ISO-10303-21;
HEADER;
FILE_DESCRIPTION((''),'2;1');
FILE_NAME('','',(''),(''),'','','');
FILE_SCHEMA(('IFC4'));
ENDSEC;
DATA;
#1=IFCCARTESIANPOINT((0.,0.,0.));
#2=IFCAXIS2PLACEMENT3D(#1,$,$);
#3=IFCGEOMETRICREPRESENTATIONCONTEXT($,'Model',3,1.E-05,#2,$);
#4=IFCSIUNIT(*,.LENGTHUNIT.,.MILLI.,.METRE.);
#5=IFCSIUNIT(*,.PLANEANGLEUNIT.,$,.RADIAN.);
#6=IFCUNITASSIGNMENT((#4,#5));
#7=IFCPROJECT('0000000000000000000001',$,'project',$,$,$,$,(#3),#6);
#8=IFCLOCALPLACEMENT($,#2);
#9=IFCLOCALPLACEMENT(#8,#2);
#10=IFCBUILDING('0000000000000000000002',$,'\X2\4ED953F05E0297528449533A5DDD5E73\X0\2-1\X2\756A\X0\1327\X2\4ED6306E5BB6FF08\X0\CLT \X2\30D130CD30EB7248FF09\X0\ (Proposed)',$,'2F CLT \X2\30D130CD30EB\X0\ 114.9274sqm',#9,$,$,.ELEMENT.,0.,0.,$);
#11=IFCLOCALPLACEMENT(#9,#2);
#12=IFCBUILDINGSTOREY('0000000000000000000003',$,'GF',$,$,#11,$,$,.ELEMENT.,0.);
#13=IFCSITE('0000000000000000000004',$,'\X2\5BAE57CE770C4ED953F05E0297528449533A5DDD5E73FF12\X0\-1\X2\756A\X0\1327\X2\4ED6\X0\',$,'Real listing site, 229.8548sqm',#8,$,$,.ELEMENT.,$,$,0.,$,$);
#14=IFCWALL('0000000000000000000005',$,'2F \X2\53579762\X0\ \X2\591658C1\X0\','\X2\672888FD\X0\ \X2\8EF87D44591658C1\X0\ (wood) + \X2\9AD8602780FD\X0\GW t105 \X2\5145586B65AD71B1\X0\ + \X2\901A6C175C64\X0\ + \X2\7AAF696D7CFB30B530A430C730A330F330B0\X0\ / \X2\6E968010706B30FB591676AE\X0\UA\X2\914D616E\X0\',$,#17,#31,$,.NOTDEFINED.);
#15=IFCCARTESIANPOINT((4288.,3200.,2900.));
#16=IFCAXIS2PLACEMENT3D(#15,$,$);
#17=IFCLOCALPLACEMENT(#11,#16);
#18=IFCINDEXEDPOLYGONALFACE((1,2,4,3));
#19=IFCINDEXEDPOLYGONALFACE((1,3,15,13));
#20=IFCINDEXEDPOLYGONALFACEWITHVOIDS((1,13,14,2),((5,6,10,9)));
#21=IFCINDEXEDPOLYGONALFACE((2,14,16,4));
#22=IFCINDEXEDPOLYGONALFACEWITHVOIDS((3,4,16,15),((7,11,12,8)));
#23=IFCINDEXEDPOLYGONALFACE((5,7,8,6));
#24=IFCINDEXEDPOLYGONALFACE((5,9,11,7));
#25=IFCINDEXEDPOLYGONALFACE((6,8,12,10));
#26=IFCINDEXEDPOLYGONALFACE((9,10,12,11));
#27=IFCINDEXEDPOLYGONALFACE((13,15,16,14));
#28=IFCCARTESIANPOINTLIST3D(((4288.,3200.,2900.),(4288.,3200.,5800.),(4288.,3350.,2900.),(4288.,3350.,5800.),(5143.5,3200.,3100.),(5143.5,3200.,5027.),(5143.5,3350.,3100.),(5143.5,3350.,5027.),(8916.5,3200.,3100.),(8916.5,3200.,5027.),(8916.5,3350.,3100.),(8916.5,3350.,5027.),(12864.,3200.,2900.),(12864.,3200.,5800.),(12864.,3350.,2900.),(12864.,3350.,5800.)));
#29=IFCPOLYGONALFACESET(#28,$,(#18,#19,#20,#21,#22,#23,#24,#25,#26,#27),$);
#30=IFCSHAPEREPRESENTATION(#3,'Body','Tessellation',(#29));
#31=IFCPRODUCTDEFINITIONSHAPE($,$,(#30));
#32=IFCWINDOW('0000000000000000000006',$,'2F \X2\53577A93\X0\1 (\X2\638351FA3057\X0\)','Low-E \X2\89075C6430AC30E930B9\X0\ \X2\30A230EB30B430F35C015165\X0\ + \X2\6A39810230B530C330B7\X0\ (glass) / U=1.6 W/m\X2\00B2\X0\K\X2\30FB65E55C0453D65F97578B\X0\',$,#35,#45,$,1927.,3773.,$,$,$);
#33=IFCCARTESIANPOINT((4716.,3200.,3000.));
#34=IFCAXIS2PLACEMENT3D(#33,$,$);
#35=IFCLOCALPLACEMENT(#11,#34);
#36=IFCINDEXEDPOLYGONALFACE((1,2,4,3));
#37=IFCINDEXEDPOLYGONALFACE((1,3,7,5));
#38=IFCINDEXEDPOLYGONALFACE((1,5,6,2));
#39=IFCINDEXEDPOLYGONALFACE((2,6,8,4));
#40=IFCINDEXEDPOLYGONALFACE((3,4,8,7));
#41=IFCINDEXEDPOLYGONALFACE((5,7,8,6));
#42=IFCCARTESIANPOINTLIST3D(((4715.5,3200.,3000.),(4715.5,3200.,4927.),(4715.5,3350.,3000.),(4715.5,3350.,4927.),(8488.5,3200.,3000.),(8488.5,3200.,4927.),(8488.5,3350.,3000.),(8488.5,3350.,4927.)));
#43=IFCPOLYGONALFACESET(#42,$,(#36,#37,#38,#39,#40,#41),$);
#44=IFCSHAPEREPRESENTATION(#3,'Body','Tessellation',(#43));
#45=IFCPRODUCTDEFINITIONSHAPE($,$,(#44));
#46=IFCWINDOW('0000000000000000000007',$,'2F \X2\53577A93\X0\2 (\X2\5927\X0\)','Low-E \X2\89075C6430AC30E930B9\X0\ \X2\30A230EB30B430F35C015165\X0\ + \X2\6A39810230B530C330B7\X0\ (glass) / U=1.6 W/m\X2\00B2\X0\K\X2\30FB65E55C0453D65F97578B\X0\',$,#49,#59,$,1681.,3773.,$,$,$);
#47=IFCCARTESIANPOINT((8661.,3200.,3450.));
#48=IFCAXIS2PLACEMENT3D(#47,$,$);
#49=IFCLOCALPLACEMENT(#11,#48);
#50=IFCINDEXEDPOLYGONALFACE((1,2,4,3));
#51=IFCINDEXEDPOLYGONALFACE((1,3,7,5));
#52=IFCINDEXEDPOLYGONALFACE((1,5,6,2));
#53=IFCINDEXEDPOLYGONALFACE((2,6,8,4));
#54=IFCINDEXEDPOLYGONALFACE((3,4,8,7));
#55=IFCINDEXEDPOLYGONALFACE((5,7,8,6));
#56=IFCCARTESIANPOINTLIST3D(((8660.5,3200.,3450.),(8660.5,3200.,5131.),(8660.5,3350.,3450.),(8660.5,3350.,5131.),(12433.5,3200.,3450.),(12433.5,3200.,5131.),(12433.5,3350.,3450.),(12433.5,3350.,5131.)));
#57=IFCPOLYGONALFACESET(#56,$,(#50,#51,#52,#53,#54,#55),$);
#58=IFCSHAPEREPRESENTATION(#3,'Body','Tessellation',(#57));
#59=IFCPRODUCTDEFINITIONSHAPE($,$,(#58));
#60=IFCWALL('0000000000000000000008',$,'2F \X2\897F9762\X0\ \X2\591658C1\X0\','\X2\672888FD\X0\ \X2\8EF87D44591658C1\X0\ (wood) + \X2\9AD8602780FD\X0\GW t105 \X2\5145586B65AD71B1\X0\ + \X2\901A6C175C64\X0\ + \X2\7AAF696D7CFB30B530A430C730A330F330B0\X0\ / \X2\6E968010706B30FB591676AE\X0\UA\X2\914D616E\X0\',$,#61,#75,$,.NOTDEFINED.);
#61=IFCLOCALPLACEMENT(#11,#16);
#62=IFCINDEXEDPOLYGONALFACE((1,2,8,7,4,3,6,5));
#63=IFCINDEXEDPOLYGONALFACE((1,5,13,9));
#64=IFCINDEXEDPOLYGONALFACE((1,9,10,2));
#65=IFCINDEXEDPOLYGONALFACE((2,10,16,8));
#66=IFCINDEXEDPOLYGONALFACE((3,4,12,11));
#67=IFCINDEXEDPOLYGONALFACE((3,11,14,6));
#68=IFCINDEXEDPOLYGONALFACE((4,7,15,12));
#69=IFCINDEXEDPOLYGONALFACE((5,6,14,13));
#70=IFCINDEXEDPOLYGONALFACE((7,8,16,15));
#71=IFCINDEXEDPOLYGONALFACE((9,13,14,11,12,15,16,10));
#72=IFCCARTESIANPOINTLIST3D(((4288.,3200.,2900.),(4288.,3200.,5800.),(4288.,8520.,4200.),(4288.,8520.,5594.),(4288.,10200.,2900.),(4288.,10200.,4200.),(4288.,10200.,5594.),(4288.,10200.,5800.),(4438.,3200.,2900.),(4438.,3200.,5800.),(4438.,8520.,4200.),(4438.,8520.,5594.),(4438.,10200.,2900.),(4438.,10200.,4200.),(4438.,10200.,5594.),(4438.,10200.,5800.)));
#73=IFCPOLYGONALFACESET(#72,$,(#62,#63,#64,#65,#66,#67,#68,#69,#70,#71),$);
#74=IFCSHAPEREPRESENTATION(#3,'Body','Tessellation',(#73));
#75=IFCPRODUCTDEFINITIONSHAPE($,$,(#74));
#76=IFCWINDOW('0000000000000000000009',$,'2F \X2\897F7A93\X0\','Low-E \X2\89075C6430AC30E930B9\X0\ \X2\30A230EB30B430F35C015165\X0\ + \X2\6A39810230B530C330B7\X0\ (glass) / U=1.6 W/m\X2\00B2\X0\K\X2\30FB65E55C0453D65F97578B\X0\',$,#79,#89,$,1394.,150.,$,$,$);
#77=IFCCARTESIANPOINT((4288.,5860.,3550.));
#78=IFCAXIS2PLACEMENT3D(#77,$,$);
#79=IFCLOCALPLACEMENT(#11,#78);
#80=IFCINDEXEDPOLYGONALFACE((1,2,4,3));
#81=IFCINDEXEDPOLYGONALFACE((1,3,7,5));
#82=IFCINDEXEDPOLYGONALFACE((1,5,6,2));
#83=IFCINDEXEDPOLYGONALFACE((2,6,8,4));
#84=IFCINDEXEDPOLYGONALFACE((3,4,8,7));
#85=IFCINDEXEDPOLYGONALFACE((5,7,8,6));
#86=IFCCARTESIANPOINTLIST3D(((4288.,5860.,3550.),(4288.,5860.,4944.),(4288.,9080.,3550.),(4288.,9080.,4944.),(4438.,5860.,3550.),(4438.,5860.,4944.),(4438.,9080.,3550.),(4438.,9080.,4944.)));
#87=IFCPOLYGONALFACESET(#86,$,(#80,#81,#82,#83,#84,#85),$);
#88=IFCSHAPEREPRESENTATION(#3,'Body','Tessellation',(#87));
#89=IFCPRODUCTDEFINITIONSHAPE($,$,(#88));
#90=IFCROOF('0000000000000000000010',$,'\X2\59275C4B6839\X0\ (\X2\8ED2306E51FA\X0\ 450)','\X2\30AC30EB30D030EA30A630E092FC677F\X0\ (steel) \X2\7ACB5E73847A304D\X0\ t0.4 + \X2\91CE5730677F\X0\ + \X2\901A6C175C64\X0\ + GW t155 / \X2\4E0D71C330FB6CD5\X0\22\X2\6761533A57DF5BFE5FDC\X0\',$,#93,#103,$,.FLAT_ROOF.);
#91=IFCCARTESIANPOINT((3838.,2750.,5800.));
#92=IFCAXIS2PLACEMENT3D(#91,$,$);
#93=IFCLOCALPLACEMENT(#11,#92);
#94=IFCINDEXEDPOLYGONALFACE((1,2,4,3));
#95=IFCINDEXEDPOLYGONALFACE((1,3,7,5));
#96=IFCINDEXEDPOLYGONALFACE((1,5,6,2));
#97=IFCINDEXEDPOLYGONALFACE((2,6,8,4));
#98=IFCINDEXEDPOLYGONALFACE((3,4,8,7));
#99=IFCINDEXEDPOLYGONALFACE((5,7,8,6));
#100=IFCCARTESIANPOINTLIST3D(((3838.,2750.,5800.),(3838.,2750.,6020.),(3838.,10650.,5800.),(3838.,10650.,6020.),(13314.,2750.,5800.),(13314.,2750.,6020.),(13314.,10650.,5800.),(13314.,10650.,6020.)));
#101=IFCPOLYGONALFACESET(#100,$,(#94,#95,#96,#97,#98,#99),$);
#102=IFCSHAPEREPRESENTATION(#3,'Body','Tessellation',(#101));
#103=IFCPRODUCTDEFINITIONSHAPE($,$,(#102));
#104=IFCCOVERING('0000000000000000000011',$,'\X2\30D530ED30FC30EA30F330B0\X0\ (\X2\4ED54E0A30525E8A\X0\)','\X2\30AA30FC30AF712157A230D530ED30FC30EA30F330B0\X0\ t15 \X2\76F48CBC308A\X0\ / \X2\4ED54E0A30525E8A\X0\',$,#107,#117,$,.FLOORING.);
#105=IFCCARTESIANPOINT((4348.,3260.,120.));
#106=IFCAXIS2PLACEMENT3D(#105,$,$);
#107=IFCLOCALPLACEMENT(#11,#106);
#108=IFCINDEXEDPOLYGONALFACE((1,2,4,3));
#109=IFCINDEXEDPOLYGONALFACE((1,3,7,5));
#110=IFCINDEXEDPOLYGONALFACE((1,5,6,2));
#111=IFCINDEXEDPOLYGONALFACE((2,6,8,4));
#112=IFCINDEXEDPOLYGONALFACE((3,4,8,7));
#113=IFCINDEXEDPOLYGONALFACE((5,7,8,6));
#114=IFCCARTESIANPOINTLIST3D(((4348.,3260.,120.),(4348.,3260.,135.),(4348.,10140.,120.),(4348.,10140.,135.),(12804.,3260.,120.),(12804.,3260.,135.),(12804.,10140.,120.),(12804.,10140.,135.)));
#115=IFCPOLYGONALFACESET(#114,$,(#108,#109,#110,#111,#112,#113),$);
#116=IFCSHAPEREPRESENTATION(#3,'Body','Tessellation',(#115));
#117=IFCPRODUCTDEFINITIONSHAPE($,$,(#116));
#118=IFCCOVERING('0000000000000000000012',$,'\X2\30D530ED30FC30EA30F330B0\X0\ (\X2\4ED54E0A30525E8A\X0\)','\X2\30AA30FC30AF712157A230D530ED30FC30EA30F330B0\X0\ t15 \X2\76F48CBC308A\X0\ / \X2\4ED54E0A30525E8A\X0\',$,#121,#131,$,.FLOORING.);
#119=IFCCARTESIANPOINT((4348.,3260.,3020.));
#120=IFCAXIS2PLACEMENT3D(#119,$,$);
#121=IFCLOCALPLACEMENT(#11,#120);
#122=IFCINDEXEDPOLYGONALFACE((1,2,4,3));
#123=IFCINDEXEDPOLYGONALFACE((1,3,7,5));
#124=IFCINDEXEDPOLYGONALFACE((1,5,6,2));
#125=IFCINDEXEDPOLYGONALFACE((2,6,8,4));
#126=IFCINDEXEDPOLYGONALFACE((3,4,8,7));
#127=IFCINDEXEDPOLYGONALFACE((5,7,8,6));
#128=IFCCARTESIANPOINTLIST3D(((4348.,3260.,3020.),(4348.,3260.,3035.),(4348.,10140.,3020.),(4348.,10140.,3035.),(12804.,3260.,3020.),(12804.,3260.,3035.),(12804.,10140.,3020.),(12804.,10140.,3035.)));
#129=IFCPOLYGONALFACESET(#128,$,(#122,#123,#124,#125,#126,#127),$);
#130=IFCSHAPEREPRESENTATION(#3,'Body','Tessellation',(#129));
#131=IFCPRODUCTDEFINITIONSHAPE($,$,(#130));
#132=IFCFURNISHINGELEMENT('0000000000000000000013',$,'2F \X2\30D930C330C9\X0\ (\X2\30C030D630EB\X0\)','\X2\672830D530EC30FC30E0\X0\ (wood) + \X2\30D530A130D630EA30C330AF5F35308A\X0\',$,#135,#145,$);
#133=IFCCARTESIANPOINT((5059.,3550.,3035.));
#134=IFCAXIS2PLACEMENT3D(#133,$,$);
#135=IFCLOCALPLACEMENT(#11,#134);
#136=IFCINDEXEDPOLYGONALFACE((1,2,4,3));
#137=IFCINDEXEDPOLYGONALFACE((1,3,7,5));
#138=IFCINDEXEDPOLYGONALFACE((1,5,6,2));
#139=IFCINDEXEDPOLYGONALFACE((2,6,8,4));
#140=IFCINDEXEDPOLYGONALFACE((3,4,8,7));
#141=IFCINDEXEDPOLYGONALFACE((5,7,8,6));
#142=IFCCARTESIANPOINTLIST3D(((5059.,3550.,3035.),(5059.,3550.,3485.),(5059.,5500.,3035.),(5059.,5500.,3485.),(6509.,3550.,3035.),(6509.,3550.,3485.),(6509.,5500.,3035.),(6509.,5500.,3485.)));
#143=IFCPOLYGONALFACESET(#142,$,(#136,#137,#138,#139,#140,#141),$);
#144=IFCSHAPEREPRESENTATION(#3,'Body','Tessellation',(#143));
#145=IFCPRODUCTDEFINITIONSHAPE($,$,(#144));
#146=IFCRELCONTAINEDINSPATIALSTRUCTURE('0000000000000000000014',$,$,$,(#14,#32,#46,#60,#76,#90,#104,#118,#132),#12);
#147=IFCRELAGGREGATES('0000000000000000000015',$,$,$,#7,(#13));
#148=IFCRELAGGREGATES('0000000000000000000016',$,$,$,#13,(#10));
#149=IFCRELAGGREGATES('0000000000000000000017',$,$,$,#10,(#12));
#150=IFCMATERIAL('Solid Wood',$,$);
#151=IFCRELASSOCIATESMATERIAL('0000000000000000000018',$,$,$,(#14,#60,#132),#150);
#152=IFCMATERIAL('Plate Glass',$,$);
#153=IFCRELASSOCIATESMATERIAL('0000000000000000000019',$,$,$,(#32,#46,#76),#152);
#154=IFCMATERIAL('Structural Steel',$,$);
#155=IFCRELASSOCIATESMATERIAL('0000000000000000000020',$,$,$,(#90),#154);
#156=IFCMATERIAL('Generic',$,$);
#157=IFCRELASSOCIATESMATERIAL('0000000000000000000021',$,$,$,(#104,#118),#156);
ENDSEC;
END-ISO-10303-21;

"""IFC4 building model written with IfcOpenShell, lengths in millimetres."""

from ifc_helpers import new_model, si_unit, frame, frame_2d, origin, place, context, project, spatial, rectangle, extrude, material, element, fill, save


model = new_model("IFC4")

# Units and contexts
model_context = context("Model", 3, precision=1e-05, world=origin())
ifc_project = project(units=[si_unit("LENGTHUNIT", "METRE", prefix="MILLI"), si_unit("PLANEANGLEUNIT", "RADIAN")], contexts=[model_context])

# Site, building, storey
site_placement = place(None, origin())
site = spatial("IfcSite", under=ifc_project, at=site_placement, Name="宮城県仙台市青葉区川平２-1番1327他", ObjectType="Real listing site, 229.8548sqm", CompositionType="ELEMENT", RefElevation=0.0)
building_placement = place(site_placement, origin())
building = spatial("IfcBuilding", under=site, at=building_placement, Name="仙台市青葉区川平2-1番1327他の家（CLT パネル版） (Proposed)", ObjectType="2F CLT パネル 114.9274sqm", CompositionType="ELEMENT", ElevationOfRefHeight=0.0, ElevationOfTerrain=0.0)
storey_placement = place(building_placement, origin())
storey = spatial("IfcBuildingStorey", under=building, at=storey_placement, Name="GF", CompositionType="ELEMENT", Elevation=0.0)

# Shared definitions
ifc_material_1 = material(Name="Solid Wood")

# Shared definitions
ifc_material_2 = material(Name="Plate Glass")

# Wall, openings, windows
wall_1_placement = place(storey_placement, frame((4288.0, 3200.0, 2900.0)))
wall_1 = element("IfcWall", 1, at=wall_1_placement, inside=storey, material=ifc_material_1, Name="2F 南面 外壁", Description="木製 軸組外壁 (wood) + 高性能GW t105 充填断熱 + 通気層 + 窯業系サイディング / 準耐火・外皮UA配慮", PredefinedType="NOTDEFINED", context=model_context, shape_type="SweptSolid", body=[
    extrude(rectangle(XDim=8576.0, YDim=150.0, at=frame_2d((4288.0, 75.0))), frame((4288.0, 3200.0, 2900.0)), (0.0, 0.0, 1.0), 2900.0),
])
opening_1_placement = place(storey_placement, frame((4716.0, 3200.0, 3000.0)))
opening_1 = element("IfcOpeningElement", 2, at=opening_1_placement, cuts=wall_1, PredefinedType="NOTDEFINED", context=model_context, shape_type="SweptSolid", body=[
    extrude(rectangle(XDim=3773.0, YDim=150.0, at=frame_2d((1886.0, 75.0))), frame((4716.0, 3200.0, 3000.0)), (0.0, 0.0, 1.0), 1927.0),
])
opening_2_placement = place(storey_placement, frame((8661.0, 3200.0, 3450.0)))
opening_2 = element("IfcOpeningElement", 3, at=opening_2_placement, cuts=wall_1, PredefinedType="NOTDEFINED", context=model_context, shape_type="SweptSolid", body=[
    extrude(rectangle(XDim=3773.0, YDim=150.0, at=frame_2d((1886.0, 75.0))), frame((8661.0, 3200.0, 3450.0)), (0.0, 0.0, 1.0), 1681.0),
])
window_1_placement = place(storey_placement, frame((4716.0, 3200.0, 3000.0)))
window_1 = element("IfcWindow", 4, at=window_1_placement, inside=storey, material=ifc_material_2, Name="2F 南窓1 (掃出し)", Description="Low-E 複層ガラス アルゴン封入 + 樹脂サッシ (glass) / U=1.6 W/m²K・日射取得型", OverallHeight=1927.0, OverallWidth=3773.0, context=model_context, shape_type="SweptSolid", body=[
    extrude(rectangle(XDim=3773.0, YDim=150.0, at=frame_2d((1886.0, 75.0))), frame((4716.0, 3200.0, 3000.0)), (0.0, 0.0, 1.0), 1927.0),
])
fill(opening_1, window_1)
window_2_placement = place(storey_placement, frame((8661.0, 3200.0, 3450.0)))
window_2 = element("IfcWindow", 5, at=window_2_placement, inside=storey, material=ifc_material_2, Name="2F 南窓2 (大)", Description="Low-E 複層ガラス アルゴン封入 + 樹脂サッシ (glass) / U=1.6 W/m²K・日射取得型", OverallHeight=1681.0, OverallWidth=3773.0, context=model_context, shape_type="SweptSolid", body=[
    extrude(rectangle(XDim=3773.0, YDim=150.0, at=frame_2d((1886.0, 75.0))), frame((8661.0, 3200.0, 3450.0)), (0.0, 0.0, 1.0), 1681.0),
])
fill(opening_2, window_2)

# Wall, opening, window
wall_2_placement = place(storey_placement, frame((4288.0, 3200.0, 2900.0)))
wall_2 = element("IfcWall", 6, at=wall_2_placement, inside=storey, material=ifc_material_1, Name="2F 西面 外壁", Description="木製 軸組外壁 (wood) + 高性能GW t105 充填断熱 + 通気層 + 窯業系サイディング / 準耐火・外皮UA配慮", PredefinedType="NOTDEFINED", context=model_context, shape_type="SweptSolid", body=[
    extrude(rectangle(XDim=150.0, YDim=7000.0, at=frame_2d((75.0, 3500.0))), frame((4288.0, 3200.0, 2900.0)), (0.0, 0.0, 1.0), 2900.0),
])
opening_3_placement = place(storey_placement, frame((4288.0, 5860.0, 3550.0)))
opening_3 = element("IfcOpeningElement", 7, at=opening_3_placement, cuts=wall_2, PredefinedType="NOTDEFINED", context=model_context, shape_type="SweptSolid", body=[
    extrude(rectangle(XDim=150.0, YDim=3220.0, at=frame_2d((75.0, 1610.0))), frame((4288.0, 5860.0, 3550.0)), (0.0, 0.0, 1.0), 1394.0),
])
window_3_placement = place(storey_placement, frame((4288.0, 5860.0, 3550.0)))
window_3 = element("IfcWindow", 8, at=window_3_placement, inside=storey, material=ifc_material_2, Name="2F 西窓", Description="Low-E 複層ガラス アルゴン封入 + 樹脂サッシ (glass) / U=1.6 W/m²K・日射取得型", OverallHeight=1394.0, OverallWidth=150.0, context=model_context, shape_type="SweptSolid", body=[
    extrude(rectangle(XDim=150.0, YDim=3220.0, at=frame_2d((75.0, 1610.0))), frame((4288.0, 5860.0, 3550.0)), (0.0, 0.0, 1.0), 1394.0),
])
fill(opening_3, window_3)

# Roof
ifc_material_3 = material(Name="Structural Steel")
roof_placement = place(storey_placement, frame((3838.0, 2750.0, 5800.0)))
element("IfcRoof", 9, at=roof_placement, inside=storey, material=ifc_material_3, Name="大屋根 (軒の出 450)", Description="ガルバリウム鋼板 (steel) 立平葺き t0.4 + 野地板 + 通気層 + GW t155 / 不燃・法22条区域対応", PredefinedType="FLAT_ROOF", context=model_context, shape_type="SweptSolid", body=[
    extrude(rectangle(XDim=9476.0, YDim=7900.0, at=frame_2d((4738.0, 3950.0))), frame((3838.0, 2750.0, 5800.0)), (0.0, 0.0, 1.0), 220.0),
])

# Coverings
ifc_material_4 = material(Name="Generic")
covering_1_placement = place(storey_placement, frame((4348.0, 3260.0, 120.0)))
element("IfcCovering", 10, at=covering_1_placement, inside=storey, material=ifc_material_4, Name="フローリング (仕上げ床)", Description="オーク無垢フローリング t15 直貼り / 仕上げ床", PredefinedType="FLOORING", context=model_context, shape_type="SweptSolid", body=[
    extrude(rectangle(XDim=8456.0, YDim=6880.0, at=frame_2d((4228.0, 3440.0))), frame((4348.0, 3260.0, 120.0)), (0.0, 0.0, 1.0), 15.0),
])
covering_2_placement = place(storey_placement, frame((4348.0, 3260.0, 3020.0)))
element("IfcCovering", 11, at=covering_2_placement, inside=storey, material=ifc_material_4, Name="フローリング (仕上げ床)", Description="オーク無垢フローリング t15 直貼り / 仕上げ床", PredefinedType="FLOORING", context=model_context, shape_type="SweptSolid", body=[
    extrude(rectangle(XDim=8456.0, YDim=6880.0, at=frame_2d((4228.0, 3440.0))), frame((4348.0, 3260.0, 3020.0)), (0.0, 0.0, 1.0), 15.0),
])

# Furnishing element
furnishing_placement = place(storey_placement, frame((5059.0, 3550.0, 3035.0)))
element("IfcFurnishingElement", 12, at=furnishing_placement, inside=storey, material=ifc_material_1, Name="2F ベッド (ダブル)", Description="木フレーム (wood) + ファブリック張り", context=model_context, shape_type="SweptSolid", body=[
    extrude(rectangle(XDim=1450.0, YDim=1950.0, at=frame_2d((725.0, 975.0))), frame((5059.0, 3550.0, 3035.0)), (0.0, 0.0, 1.0), 450.0),
])

save(model, "model.ifc")
